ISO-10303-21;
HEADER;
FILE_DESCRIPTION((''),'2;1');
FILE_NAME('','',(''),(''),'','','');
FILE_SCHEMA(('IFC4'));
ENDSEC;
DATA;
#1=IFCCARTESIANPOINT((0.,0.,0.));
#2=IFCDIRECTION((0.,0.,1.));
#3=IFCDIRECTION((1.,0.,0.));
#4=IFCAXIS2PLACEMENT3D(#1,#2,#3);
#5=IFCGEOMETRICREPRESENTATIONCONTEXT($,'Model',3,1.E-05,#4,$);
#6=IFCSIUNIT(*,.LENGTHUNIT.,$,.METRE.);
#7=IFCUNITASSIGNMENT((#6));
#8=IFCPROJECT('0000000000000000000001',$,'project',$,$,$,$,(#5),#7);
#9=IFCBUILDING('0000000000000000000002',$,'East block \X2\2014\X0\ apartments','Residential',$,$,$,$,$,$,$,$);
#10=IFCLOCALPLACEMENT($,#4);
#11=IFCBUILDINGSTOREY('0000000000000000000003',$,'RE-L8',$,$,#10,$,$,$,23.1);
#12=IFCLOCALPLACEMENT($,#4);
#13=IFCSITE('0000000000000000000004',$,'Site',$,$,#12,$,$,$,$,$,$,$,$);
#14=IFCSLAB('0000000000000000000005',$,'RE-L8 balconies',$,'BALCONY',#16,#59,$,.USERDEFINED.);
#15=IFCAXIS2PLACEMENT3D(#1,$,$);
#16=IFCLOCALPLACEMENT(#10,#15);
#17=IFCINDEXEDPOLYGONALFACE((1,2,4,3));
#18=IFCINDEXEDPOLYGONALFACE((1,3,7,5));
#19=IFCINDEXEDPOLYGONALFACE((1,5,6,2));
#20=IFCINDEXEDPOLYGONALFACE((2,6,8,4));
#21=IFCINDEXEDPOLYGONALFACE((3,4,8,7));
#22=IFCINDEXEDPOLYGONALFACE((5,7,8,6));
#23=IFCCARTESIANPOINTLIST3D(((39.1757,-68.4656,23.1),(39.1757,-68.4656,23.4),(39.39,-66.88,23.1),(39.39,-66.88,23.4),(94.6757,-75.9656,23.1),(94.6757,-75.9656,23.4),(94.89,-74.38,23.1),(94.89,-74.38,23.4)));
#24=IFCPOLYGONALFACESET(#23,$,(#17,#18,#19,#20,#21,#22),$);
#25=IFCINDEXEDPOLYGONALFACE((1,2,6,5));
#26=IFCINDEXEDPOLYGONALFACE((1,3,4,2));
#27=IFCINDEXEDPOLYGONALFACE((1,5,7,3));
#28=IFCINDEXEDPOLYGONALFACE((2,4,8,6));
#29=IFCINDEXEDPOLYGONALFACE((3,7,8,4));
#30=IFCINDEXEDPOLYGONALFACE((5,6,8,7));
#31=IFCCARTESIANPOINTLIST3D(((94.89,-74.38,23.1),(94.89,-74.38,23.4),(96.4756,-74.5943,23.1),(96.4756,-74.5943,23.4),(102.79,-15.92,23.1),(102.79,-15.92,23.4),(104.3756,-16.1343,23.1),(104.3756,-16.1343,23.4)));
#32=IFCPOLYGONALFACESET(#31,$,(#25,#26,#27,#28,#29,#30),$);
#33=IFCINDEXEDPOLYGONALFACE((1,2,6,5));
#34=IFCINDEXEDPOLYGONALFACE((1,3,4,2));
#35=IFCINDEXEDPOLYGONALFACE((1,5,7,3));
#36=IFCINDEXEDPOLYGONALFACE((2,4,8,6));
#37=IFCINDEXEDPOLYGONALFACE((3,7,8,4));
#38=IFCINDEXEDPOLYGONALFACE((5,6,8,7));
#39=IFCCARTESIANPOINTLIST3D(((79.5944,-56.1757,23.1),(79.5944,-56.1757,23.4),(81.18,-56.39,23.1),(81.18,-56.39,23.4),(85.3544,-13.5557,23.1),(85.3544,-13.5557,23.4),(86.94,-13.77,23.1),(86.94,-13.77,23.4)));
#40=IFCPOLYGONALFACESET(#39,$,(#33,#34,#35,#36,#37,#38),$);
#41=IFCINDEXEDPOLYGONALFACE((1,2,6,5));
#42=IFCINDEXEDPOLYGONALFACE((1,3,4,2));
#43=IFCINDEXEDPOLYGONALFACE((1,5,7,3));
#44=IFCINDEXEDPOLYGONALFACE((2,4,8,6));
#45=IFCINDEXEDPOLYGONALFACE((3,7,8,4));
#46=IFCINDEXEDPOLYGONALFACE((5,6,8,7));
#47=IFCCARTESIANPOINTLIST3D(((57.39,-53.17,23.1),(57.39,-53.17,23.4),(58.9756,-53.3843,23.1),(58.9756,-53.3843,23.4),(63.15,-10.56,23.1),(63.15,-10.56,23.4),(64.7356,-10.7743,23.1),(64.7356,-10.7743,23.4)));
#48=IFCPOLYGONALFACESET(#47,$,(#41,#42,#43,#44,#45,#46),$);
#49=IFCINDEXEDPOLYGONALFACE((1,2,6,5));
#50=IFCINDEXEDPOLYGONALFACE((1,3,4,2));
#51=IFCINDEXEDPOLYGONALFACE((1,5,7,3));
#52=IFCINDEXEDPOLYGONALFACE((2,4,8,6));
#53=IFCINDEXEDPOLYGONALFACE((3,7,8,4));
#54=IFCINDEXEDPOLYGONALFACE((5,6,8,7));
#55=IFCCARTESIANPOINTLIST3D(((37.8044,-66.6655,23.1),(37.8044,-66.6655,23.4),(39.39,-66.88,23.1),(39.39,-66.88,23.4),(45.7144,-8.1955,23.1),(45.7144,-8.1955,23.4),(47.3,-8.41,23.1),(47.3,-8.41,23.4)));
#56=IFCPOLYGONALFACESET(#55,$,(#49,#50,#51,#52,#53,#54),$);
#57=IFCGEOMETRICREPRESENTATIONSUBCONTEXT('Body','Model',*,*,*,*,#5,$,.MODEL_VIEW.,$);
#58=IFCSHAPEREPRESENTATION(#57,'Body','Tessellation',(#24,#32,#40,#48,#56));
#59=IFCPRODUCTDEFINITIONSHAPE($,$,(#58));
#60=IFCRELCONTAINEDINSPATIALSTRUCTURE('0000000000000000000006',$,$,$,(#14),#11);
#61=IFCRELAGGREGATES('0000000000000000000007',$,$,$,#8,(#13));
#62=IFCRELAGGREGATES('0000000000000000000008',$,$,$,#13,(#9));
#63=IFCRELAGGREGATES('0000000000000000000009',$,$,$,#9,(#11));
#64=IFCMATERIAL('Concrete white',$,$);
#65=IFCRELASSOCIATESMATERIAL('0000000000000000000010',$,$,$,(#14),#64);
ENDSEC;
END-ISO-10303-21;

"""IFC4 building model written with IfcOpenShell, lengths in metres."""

from ifc_helpers import new_model, si_unit, frame, origin_with_axes, place, context, subcontext, project, spatial, polyline, outline, extrude, material, element, save


model = new_model("IFC4")

# Units and contexts
model_context = context("Model", 3, precision=1e-05, world=origin_with_axes())
body_context = subcontext(model_context, "Body", "Model", "MODEL_VIEW")
ifc_project = project(units=[si_unit("LENGTHUNIT", "METRE")], contexts=[model_context])

# Site, building, storey
site_placement = place(None, origin_with_axes())
site = spatial("IfcSite", under=ifc_project, at=site_placement, Name="Site")
building = spatial("IfcBuilding", under=site, Name="East block — apartments", Description="Residential")
storey_placement = place(None, origin_with_axes())
storey = spatial("IfcBuildingStorey", under=building, at=storey_placement, Name="RE-L8", Elevation=23.1)

# Slab
ifc_material_1 = material(Name="Concrete white")
slab_placement = place(storey_placement, origin_with_axes())
element("IfcSlab", 1, at=slab_placement, inside=storey, material=ifc_material_1, Name="RE-L8 balconies", ObjectType="BALCONY", PredefinedType="USERDEFINED", context=body_context, shape_type="SweptSolid", body=[
    extrude(outline(polyline([(39.39, -66.88), (94.89, -74.38), (94.6757, -75.9656), (39.1757, -68.4656), (39.39, -66.88)])), frame((0.0, 0.0, 23.1), z_axis=(0.0, 0.0, 1.0), x_axis=(1.0, 0.0, 0.0)), (0.0, 0.0, 1.0), 0.3),
    extrude(outline(polyline([(94.89, -74.38), (102.79, -15.92), (104.3756, -16.1343), (96.4756, -74.5943), (94.89, -74.38)])), frame((0.0, 0.0, 23.1), z_axis=(0.0, 0.0, 1.0), x_axis=(1.0, 0.0, 0.0)), (0.0, 0.0, 1.0), 0.3),
    extrude(outline(polyline([(86.94, -13.77), (81.18, -56.39), (79.5944, -56.1757), (85.3544, -13.5557), (86.94, -13.77)])), frame((0.0, 0.0, 23.1), z_axis=(0.0, 0.0, 1.0), x_axis=(1.0, 0.0, 0.0)), (0.0, 0.0, 1.0), 0.3),
    extrude(outline(polyline([(57.39, -53.17), (63.15, -10.56), (64.7356, -10.7743), (58.9756, -53.3843), (57.39, -53.17)])), frame((0.0, 0.0, 23.1), z_axis=(0.0, 0.0, 1.0), x_axis=(1.0, 0.0, 0.0)), (0.0, 0.0, 1.0), 0.3),
    extrude(outline(polyline([(47.3, -8.41), (39.39, -66.88), (37.8044, -66.6655), (45.7144, -8.1955), (47.3, -8.41)])), frame((0.0, 0.0, 23.1), z_axis=(0.0, 0.0, 1.0), x_axis=(1.0, 0.0, 0.0)), (0.0, 0.0, 1.0), 0.3),
])

save(model, "model.ifc")
